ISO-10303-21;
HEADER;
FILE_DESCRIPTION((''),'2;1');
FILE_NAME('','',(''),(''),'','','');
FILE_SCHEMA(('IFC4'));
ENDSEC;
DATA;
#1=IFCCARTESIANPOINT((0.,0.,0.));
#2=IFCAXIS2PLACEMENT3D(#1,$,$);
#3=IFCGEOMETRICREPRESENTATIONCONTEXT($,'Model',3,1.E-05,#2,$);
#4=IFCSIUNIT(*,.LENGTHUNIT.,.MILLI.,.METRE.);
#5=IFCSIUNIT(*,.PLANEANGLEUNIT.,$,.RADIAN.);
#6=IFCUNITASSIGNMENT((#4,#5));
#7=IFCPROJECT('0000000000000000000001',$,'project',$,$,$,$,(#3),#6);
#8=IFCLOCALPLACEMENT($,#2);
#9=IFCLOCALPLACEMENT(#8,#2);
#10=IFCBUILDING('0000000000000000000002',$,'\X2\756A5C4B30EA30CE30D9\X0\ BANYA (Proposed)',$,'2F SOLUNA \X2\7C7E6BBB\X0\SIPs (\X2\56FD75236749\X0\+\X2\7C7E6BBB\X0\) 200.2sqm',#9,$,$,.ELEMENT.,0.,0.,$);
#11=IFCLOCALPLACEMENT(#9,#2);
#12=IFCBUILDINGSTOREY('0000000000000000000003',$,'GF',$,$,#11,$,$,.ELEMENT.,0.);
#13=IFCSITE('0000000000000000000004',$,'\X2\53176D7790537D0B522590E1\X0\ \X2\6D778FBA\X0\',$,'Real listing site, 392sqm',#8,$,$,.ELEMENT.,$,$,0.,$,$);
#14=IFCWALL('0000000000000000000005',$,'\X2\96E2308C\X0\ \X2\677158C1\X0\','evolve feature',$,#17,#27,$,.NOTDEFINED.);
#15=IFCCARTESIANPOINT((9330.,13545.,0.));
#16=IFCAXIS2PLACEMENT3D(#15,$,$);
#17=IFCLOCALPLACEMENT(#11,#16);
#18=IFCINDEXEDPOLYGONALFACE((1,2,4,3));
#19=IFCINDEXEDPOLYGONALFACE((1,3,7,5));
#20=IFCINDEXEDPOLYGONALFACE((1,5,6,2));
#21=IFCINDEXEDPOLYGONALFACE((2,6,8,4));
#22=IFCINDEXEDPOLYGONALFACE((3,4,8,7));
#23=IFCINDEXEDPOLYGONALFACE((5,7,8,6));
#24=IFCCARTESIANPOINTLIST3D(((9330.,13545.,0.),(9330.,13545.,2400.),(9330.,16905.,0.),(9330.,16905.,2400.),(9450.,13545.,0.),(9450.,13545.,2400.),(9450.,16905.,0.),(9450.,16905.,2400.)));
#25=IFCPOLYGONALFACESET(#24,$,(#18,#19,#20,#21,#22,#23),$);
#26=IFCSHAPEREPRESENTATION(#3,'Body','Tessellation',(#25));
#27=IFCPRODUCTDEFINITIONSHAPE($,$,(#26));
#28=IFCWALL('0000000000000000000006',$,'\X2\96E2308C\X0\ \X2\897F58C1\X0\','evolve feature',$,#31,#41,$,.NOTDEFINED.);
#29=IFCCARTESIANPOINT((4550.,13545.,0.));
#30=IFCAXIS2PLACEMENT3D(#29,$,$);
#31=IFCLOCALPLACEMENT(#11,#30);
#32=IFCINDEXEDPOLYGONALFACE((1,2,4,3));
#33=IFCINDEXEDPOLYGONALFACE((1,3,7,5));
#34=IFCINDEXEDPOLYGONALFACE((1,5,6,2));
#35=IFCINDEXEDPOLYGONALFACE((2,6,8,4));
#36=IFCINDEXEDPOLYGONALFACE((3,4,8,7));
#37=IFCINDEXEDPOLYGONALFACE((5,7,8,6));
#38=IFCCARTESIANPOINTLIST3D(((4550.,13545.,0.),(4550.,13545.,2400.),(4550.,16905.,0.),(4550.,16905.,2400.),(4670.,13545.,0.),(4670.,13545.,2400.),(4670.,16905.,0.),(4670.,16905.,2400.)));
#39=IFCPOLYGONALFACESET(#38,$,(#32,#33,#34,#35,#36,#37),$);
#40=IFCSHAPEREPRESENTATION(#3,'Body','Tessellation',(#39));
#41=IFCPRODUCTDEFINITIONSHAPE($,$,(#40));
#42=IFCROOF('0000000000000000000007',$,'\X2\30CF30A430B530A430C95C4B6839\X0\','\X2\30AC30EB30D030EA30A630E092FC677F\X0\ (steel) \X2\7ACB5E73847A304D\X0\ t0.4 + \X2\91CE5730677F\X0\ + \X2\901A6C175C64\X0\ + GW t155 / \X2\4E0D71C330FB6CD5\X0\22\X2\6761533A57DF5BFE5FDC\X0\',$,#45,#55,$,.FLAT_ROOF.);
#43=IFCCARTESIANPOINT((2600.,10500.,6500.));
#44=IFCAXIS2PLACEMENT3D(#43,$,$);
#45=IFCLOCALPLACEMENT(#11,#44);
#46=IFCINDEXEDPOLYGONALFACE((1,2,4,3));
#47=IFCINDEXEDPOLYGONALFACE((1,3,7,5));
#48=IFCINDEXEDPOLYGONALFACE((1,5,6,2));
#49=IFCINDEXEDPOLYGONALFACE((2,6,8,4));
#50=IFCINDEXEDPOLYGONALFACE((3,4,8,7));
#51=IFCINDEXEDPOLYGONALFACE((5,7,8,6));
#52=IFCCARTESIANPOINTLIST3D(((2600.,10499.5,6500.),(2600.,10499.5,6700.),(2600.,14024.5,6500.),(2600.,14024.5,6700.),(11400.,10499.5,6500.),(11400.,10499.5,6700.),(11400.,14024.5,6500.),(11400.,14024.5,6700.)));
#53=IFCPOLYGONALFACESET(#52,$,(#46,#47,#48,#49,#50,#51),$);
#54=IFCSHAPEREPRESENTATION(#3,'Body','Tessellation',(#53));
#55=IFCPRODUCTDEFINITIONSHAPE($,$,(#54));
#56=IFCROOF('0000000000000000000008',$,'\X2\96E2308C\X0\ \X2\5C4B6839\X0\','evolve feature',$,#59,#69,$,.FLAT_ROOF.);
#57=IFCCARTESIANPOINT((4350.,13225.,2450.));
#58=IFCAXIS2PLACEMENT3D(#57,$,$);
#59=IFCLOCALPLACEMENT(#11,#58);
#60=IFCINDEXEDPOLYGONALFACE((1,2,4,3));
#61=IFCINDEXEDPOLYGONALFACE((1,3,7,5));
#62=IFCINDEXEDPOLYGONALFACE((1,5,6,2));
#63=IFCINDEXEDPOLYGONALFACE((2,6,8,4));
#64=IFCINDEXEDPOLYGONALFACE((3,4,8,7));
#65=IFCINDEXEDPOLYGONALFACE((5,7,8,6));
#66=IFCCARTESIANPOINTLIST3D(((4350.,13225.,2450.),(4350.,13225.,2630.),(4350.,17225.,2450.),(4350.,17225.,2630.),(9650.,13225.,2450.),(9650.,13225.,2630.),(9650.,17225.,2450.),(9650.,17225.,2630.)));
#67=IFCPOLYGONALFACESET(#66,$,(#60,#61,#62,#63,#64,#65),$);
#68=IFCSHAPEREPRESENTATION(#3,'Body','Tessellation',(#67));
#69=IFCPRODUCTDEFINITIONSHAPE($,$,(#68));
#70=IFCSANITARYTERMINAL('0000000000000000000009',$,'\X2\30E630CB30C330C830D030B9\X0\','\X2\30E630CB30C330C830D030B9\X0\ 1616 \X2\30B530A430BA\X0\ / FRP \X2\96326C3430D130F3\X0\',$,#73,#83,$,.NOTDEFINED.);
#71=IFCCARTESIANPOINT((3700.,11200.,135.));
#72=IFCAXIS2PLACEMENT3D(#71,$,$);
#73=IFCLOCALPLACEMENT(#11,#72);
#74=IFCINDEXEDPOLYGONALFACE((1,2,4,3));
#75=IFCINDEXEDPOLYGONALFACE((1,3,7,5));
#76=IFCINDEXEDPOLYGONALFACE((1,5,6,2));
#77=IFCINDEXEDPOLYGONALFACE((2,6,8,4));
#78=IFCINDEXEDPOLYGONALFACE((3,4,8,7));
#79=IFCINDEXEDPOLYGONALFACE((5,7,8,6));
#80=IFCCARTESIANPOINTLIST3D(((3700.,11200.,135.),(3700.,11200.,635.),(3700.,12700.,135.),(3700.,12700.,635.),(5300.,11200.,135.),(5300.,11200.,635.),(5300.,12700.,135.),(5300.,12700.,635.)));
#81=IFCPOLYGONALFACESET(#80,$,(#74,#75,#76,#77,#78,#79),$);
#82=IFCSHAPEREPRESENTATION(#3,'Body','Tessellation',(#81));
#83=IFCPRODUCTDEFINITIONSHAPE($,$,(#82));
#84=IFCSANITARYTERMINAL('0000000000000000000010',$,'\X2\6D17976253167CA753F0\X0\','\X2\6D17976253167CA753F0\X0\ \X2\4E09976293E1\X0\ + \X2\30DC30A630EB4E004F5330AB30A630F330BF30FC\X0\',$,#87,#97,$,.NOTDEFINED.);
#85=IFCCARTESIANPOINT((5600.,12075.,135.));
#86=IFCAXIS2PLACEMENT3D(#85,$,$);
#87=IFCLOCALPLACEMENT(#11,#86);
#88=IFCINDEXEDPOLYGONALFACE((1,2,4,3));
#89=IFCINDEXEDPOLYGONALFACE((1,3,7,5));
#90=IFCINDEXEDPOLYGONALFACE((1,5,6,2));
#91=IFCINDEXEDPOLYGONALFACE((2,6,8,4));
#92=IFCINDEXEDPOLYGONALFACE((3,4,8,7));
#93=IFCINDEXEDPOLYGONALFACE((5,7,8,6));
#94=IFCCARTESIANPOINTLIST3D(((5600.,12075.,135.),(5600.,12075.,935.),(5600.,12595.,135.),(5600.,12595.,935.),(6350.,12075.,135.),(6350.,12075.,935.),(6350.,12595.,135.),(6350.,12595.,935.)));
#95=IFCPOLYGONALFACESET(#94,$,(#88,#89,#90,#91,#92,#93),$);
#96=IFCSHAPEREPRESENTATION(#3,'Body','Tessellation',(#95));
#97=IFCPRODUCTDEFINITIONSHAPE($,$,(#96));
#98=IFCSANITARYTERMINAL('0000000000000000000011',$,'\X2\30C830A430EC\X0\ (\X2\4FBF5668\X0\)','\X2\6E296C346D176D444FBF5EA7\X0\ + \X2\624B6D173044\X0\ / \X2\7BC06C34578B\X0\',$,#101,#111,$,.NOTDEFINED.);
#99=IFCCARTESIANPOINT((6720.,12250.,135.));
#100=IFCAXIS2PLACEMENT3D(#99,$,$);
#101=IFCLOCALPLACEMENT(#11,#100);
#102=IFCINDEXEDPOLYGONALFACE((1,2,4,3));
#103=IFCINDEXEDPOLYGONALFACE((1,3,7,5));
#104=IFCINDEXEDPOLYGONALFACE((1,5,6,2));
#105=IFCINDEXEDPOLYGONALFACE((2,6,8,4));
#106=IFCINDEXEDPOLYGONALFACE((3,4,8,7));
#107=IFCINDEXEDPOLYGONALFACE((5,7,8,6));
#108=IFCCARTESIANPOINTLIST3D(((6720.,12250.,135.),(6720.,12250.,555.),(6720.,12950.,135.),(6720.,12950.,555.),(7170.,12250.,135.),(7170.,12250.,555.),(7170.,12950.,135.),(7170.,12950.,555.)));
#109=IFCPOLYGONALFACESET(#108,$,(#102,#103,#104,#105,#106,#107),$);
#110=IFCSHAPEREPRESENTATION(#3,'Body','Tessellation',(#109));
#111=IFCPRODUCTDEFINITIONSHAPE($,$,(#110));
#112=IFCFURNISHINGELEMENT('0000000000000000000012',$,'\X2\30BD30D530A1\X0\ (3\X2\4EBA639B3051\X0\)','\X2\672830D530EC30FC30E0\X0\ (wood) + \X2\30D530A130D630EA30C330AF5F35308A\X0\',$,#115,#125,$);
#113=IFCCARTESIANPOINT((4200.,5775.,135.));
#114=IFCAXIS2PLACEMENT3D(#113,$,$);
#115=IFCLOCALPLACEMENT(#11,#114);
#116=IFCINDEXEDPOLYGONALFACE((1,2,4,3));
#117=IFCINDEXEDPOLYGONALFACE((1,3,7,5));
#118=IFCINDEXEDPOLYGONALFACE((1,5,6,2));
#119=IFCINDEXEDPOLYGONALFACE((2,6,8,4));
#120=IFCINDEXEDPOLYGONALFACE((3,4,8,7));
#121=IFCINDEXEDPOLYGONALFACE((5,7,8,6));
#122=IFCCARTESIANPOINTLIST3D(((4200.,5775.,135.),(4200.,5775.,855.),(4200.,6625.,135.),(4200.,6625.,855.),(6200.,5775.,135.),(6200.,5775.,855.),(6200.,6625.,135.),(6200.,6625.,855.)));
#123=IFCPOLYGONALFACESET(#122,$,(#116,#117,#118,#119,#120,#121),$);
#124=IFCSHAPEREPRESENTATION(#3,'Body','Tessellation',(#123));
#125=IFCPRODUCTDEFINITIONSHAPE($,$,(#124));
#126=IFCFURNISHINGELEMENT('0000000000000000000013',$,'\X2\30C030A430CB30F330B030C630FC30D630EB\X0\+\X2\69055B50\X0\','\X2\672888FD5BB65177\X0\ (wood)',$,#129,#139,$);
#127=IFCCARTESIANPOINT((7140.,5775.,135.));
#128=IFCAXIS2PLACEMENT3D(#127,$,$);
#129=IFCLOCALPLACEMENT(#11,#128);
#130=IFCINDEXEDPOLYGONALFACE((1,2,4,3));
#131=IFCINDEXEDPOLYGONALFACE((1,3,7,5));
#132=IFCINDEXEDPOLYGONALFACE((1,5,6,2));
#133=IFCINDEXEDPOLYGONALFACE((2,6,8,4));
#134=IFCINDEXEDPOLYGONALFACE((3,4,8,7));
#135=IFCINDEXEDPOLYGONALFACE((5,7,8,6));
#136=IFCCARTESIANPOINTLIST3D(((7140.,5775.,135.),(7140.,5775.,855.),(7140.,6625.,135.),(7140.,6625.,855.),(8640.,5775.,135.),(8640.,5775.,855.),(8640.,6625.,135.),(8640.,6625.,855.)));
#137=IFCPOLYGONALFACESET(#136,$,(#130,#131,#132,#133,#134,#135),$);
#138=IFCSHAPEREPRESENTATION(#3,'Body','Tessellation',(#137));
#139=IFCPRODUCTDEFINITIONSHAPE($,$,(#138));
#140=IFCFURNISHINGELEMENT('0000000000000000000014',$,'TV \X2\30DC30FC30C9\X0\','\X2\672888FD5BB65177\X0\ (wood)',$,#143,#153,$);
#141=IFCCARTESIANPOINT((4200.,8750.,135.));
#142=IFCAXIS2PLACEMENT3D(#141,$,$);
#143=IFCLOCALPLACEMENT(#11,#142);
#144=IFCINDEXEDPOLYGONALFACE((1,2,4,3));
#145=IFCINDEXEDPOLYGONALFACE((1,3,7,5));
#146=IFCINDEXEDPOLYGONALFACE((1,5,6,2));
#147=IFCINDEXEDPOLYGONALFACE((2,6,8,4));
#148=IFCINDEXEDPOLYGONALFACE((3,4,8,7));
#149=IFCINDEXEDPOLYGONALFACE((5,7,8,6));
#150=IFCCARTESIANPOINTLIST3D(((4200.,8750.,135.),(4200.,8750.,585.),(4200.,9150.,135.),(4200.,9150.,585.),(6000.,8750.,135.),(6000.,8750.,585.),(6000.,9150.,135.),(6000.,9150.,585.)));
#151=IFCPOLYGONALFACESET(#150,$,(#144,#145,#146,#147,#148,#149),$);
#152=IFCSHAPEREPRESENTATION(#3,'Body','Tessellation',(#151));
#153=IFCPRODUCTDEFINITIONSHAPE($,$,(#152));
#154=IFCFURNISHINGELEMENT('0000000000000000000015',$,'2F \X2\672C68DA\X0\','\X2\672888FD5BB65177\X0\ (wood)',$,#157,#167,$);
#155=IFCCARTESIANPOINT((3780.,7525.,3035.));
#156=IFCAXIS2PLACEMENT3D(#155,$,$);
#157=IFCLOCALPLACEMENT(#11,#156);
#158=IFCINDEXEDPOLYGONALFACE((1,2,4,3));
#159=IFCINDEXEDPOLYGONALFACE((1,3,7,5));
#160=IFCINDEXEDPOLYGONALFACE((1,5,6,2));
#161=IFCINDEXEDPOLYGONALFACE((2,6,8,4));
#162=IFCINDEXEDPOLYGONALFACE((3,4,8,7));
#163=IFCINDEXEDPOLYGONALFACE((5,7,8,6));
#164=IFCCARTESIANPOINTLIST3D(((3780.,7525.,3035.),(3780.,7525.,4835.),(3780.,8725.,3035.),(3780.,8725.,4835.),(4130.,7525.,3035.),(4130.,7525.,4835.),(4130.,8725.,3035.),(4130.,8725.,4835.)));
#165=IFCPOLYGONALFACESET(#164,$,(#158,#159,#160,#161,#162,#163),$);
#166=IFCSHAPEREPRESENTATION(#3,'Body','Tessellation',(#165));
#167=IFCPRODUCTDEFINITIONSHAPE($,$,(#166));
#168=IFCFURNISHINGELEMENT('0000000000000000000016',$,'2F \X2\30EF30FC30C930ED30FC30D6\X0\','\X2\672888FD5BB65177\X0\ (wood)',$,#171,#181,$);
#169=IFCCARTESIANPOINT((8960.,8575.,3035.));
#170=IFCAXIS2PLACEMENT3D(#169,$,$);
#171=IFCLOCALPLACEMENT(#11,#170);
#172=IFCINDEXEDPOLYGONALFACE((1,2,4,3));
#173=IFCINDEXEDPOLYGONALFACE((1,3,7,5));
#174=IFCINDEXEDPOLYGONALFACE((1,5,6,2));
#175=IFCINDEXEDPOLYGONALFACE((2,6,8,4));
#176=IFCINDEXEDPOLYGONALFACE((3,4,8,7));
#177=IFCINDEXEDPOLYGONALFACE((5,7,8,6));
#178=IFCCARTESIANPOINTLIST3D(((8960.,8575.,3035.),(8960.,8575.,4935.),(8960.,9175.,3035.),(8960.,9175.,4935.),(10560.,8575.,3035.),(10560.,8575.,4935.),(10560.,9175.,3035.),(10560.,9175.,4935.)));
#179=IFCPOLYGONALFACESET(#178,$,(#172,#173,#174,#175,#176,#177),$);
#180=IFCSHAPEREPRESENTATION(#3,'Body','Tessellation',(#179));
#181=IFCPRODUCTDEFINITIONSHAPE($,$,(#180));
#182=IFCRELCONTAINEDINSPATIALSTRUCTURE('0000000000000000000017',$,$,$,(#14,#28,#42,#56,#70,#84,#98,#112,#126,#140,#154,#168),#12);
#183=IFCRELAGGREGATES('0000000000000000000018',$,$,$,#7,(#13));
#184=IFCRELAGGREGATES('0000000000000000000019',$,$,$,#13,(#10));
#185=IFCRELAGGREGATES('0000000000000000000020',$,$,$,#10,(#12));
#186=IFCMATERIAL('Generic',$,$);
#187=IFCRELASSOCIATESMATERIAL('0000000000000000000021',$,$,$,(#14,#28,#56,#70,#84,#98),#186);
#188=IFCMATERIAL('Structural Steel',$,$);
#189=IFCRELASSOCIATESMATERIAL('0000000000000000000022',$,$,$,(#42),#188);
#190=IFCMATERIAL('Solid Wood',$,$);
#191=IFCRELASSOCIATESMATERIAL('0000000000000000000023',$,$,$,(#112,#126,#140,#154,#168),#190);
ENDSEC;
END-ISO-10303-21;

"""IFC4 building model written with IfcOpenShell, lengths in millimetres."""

from ifc_helpers import new_model, si_unit, frame, frame_2d, origin, place, context, project, spatial, rectangle, extrude, material, element, save


model = new_model("IFC4")

# Units and contexts
model_context = context("Model", 3, precision=1e-05, world=origin())
ifc_project = project(units=[si_unit("LENGTHUNIT", "METRE", prefix="MILLI"), si_unit("PLANEANGLEUNIT", "RADIAN")], contexts=[model_context])

# Site, building, storey
site_placement = place(None, origin())
site = spatial("IfcSite", under=ifc_project, at=site_placement, Name="北海道紋別郡 海辺", ObjectType="Real listing site, 392sqm", CompositionType="ELEMENT", RefElevation=0.0)
building_placement = place(site_placement, origin())
building = spatial("IfcBuilding", under=site, at=building_placement, Name="番屋リノベ BANYA (Proposed)", ObjectType="2F SOLUNA 籾殻SIPs (国産杉+籾殻) 200.2sqm", CompositionType="ELEMENT", ElevationOfRefHeight=0.0, ElevationOfTerrain=0.0)
storey_placement = place(building_placement, origin())
storey = spatial("IfcBuildingStorey", under=building, at=storey_placement, Name="GF", CompositionType="ELEMENT", Elevation=0.0)

# Shared definitions
ifc_material_1 = material(Name="Generic")

# Shared definitions
ifc_material_2 = material(Name="Solid Wood")

# Walls
wall_1_placement = place(storey_placement, frame((9330.0, 13545.0, 0.0)))
element("IfcWall", 1, at=wall_1_placement, inside=storey, material=ifc_material_1, Name="離れ 東壁", Description="evolve feature", PredefinedType="NOTDEFINED", context=model_context, shape_type="SweptSolid", body=[
    extrude(rectangle(XDim=120.0, YDim=3360.0, at=frame_2d((60.0, 1680.0))), frame((9330.0, 13545.0, 0.0)), (0.0, 0.0, 1.0), 2400.0),
])
wall_2_placement = place(storey_placement, frame((4550.0, 13545.0, 0.0)))
element("IfcWall", 2, at=wall_2_placement, inside=storey, material=ifc_material_1, Name="離れ 西壁", Description="evolve feature", PredefinedType="NOTDEFINED", context=model_context, shape_type="SweptSolid", body=[
    extrude(rectangle(XDim=120.0, YDim=3360.0, at=frame_2d((60.0, 1680.0))), frame((4550.0, 13545.0, 0.0)), (0.0, 0.0, 1.0), 2400.0),
])

# Roofs
ifc_material_3 = material(Name="Structural Steel")
roof_1_placement = place(storey_placement, frame((2600.0, 10500.0, 6500.0)))
element("IfcRoof", 3, at=roof_1_placement, inside=storey, material=ifc_material_3, Name="ハイサイド屋根", Description="ガルバリウム鋼板 (steel) 立平葺き t0.4 + 野地板 + 通気層 + GW t155 / 不燃・法22条区域対応", PredefinedType="FLAT_ROOF", context=model_context, shape_type="SweptSolid", body=[
    extrude(rectangle(XDim=8800.0, YDim=3525.0, at=frame_2d((4400.0, 1762.0))), frame((2600.0, 10500.0, 6500.0)), (0.0, 0.0, 1.0), 200.0),
])
roof_2_placement = place(storey_placement, frame((4350.0, 13225.0, 2450.0)))
element("IfcRoof", 4, at=roof_2_placement, inside=storey, material=ifc_material_1, Name="離れ 屋根", Description="evolve feature", PredefinedType="FLAT_ROOF", context=model_context, shape_type="SweptSolid", body=[
    extrude(rectangle(XDim=5300.0, YDim=4000.0, at=frame_2d((2650.0, 2000.0))), frame((4350.0, 13225.0, 2450.0)), (0.0, 0.0, 1.0), 180.0),
])

# Sanitary terminals
sanitary_terminal_1_placement = place(storey_placement, frame((3700.0, 11200.0, 135.0)))
element("IfcSanitaryTerminal", 5, at=sanitary_terminal_1_placement, inside=storey, material=ifc_material_1, Name="ユニットバス", Description="ユニットバス 1616 サイズ / FRP 防水パン", PredefinedType="NOTDEFINED", context=model_context, shape_type="SweptSolid", body=[
    extrude(rectangle(XDim=1600.0, YDim=1500.0, at=frame_2d((800.0, 750.0))), frame((3700.0, 11200.0, 135.0)), (0.0, 0.0, 1.0), 500.0),
])
sanitary_terminal_2_placement = place(storey_placement, frame((5600.0, 12075.0, 135.0)))
element("IfcSanitaryTerminal", 6, at=sanitary_terminal_2_placement, inside=storey, material=ifc_material_1, Name="洗面化粧台", Description="洗面化粧台 三面鏡 + ボウル一体カウンター", PredefinedType="NOTDEFINED", context=model_context, shape_type="SweptSolid", body=[
    extrude(rectangle(XDim=750.0, YDim=520.0, at=frame_2d((375.0, 260.0))), frame((5600.0, 12075.0, 135.0)), (0.0, 0.0, 1.0), 800.0),
])
sanitary_terminal_3_placement = place(storey_placement, frame((6720.0, 12250.0, 135.0)))
element("IfcSanitaryTerminal", 7, at=sanitary_terminal_3_placement, inside=storey, material=ifc_material_1, Name="トイレ (便器)", Description="温水洗浄便座 + 手洗い / 節水型", PredefinedType="NOTDEFINED", context=model_context, shape_type="SweptSolid", body=[
    extrude(rectangle(XDim=450.0, YDim=700.0, at=frame_2d((225.0, 350.0))), frame((6720.0, 12250.0, 135.0)), (0.0, 0.0, 1.0), 420.0),
])

# Furnishing elements
furnishing_1_placement = place(storey_placement, frame((4200.0, 5775.0, 135.0)))
element("IfcFurnishingElement", 8, at=furnishing_1_placement, inside=storey, material=ifc_material_2, Name="ソファ (3人掛け)", Description="木フレーム (wood) + ファブリック張り", context=model_context, shape_type="SweptSolid", body=[
    extrude(rectangle(XDim=2000.0, YDim=850.0, at=frame_2d((1000.0, 425.0))), frame((4200.0, 5775.0, 135.0)), (0.0, 0.0, 1.0), 720.0),
])
furnishing_2_placement = place(storey_placement, frame((7140.0, 5775.0, 135.0)))
element("IfcFurnishingElement", 9, at=furnishing_2_placement, inside=storey, material=ifc_material_2, Name="ダイニングテーブル+椅子", Description="木製家具 (wood)", context=model_context, shape_type="SweptSolid", body=[
    extrude(rectangle(XDim=1500.0, YDim=850.0, at=frame_2d((750.0, 425.0))), frame((7140.0, 5775.0, 135.0)), (0.0, 0.0, 1.0), 720.0),
])
furnishing_3_placement = place(storey_placement, frame((4200.0, 8750.0, 135.0)))
element("IfcFurnishingElement", 10, at=furnishing_3_placement, inside=storey, material=ifc_material_2, Name="TV ボード", Description="木製家具 (wood)", context=model_context, shape_type="SweptSolid", body=[
    extrude(rectangle(XDim=1800.0, YDim=400.0, at=frame_2d((900.0, 200.0))), frame((4200.0, 8750.0, 135.0)), (0.0, 0.0, 1.0), 450.0),
])
furnishing_4_placement = place(storey_placement, frame((3780.0, 7525.0, 3035.0)))
element("IfcFurnishingElement", 11, at=furnishing_4_placement, inside=storey, material=ifc_material_2, Name="2F 本棚", Description="木製家具 (wood)", context=model_context, shape_type="SweptSolid", body=[
    extrude(rectangle(XDim=350.0, YDim=1200.0, at=frame_2d((175.0, 600.0))), frame((3780.0, 7525.0, 3035.0)), (0.0, 0.0, 1.0), 1800.0),
])
furnishing_5_placement = place(storey_placement, frame((8960.0, 8575.0, 3035.0)))
element("IfcFurnishingElement", 12, at=furnishing_5_placement, inside=storey, material=ifc_material_2, Name="2F ワードローブ", Description="木製家具 (wood)", context=model_context, shape_type="SweptSolid", body=[
    extrude(rectangle(XDim=1600.0, YDim=600.0, at=frame_2d((800.0, 300.0))), frame((8960.0, 8575.0, 3035.0)), (0.0, 0.0, 1.0), 1900.0),
])

save(model, "model.ifc")
